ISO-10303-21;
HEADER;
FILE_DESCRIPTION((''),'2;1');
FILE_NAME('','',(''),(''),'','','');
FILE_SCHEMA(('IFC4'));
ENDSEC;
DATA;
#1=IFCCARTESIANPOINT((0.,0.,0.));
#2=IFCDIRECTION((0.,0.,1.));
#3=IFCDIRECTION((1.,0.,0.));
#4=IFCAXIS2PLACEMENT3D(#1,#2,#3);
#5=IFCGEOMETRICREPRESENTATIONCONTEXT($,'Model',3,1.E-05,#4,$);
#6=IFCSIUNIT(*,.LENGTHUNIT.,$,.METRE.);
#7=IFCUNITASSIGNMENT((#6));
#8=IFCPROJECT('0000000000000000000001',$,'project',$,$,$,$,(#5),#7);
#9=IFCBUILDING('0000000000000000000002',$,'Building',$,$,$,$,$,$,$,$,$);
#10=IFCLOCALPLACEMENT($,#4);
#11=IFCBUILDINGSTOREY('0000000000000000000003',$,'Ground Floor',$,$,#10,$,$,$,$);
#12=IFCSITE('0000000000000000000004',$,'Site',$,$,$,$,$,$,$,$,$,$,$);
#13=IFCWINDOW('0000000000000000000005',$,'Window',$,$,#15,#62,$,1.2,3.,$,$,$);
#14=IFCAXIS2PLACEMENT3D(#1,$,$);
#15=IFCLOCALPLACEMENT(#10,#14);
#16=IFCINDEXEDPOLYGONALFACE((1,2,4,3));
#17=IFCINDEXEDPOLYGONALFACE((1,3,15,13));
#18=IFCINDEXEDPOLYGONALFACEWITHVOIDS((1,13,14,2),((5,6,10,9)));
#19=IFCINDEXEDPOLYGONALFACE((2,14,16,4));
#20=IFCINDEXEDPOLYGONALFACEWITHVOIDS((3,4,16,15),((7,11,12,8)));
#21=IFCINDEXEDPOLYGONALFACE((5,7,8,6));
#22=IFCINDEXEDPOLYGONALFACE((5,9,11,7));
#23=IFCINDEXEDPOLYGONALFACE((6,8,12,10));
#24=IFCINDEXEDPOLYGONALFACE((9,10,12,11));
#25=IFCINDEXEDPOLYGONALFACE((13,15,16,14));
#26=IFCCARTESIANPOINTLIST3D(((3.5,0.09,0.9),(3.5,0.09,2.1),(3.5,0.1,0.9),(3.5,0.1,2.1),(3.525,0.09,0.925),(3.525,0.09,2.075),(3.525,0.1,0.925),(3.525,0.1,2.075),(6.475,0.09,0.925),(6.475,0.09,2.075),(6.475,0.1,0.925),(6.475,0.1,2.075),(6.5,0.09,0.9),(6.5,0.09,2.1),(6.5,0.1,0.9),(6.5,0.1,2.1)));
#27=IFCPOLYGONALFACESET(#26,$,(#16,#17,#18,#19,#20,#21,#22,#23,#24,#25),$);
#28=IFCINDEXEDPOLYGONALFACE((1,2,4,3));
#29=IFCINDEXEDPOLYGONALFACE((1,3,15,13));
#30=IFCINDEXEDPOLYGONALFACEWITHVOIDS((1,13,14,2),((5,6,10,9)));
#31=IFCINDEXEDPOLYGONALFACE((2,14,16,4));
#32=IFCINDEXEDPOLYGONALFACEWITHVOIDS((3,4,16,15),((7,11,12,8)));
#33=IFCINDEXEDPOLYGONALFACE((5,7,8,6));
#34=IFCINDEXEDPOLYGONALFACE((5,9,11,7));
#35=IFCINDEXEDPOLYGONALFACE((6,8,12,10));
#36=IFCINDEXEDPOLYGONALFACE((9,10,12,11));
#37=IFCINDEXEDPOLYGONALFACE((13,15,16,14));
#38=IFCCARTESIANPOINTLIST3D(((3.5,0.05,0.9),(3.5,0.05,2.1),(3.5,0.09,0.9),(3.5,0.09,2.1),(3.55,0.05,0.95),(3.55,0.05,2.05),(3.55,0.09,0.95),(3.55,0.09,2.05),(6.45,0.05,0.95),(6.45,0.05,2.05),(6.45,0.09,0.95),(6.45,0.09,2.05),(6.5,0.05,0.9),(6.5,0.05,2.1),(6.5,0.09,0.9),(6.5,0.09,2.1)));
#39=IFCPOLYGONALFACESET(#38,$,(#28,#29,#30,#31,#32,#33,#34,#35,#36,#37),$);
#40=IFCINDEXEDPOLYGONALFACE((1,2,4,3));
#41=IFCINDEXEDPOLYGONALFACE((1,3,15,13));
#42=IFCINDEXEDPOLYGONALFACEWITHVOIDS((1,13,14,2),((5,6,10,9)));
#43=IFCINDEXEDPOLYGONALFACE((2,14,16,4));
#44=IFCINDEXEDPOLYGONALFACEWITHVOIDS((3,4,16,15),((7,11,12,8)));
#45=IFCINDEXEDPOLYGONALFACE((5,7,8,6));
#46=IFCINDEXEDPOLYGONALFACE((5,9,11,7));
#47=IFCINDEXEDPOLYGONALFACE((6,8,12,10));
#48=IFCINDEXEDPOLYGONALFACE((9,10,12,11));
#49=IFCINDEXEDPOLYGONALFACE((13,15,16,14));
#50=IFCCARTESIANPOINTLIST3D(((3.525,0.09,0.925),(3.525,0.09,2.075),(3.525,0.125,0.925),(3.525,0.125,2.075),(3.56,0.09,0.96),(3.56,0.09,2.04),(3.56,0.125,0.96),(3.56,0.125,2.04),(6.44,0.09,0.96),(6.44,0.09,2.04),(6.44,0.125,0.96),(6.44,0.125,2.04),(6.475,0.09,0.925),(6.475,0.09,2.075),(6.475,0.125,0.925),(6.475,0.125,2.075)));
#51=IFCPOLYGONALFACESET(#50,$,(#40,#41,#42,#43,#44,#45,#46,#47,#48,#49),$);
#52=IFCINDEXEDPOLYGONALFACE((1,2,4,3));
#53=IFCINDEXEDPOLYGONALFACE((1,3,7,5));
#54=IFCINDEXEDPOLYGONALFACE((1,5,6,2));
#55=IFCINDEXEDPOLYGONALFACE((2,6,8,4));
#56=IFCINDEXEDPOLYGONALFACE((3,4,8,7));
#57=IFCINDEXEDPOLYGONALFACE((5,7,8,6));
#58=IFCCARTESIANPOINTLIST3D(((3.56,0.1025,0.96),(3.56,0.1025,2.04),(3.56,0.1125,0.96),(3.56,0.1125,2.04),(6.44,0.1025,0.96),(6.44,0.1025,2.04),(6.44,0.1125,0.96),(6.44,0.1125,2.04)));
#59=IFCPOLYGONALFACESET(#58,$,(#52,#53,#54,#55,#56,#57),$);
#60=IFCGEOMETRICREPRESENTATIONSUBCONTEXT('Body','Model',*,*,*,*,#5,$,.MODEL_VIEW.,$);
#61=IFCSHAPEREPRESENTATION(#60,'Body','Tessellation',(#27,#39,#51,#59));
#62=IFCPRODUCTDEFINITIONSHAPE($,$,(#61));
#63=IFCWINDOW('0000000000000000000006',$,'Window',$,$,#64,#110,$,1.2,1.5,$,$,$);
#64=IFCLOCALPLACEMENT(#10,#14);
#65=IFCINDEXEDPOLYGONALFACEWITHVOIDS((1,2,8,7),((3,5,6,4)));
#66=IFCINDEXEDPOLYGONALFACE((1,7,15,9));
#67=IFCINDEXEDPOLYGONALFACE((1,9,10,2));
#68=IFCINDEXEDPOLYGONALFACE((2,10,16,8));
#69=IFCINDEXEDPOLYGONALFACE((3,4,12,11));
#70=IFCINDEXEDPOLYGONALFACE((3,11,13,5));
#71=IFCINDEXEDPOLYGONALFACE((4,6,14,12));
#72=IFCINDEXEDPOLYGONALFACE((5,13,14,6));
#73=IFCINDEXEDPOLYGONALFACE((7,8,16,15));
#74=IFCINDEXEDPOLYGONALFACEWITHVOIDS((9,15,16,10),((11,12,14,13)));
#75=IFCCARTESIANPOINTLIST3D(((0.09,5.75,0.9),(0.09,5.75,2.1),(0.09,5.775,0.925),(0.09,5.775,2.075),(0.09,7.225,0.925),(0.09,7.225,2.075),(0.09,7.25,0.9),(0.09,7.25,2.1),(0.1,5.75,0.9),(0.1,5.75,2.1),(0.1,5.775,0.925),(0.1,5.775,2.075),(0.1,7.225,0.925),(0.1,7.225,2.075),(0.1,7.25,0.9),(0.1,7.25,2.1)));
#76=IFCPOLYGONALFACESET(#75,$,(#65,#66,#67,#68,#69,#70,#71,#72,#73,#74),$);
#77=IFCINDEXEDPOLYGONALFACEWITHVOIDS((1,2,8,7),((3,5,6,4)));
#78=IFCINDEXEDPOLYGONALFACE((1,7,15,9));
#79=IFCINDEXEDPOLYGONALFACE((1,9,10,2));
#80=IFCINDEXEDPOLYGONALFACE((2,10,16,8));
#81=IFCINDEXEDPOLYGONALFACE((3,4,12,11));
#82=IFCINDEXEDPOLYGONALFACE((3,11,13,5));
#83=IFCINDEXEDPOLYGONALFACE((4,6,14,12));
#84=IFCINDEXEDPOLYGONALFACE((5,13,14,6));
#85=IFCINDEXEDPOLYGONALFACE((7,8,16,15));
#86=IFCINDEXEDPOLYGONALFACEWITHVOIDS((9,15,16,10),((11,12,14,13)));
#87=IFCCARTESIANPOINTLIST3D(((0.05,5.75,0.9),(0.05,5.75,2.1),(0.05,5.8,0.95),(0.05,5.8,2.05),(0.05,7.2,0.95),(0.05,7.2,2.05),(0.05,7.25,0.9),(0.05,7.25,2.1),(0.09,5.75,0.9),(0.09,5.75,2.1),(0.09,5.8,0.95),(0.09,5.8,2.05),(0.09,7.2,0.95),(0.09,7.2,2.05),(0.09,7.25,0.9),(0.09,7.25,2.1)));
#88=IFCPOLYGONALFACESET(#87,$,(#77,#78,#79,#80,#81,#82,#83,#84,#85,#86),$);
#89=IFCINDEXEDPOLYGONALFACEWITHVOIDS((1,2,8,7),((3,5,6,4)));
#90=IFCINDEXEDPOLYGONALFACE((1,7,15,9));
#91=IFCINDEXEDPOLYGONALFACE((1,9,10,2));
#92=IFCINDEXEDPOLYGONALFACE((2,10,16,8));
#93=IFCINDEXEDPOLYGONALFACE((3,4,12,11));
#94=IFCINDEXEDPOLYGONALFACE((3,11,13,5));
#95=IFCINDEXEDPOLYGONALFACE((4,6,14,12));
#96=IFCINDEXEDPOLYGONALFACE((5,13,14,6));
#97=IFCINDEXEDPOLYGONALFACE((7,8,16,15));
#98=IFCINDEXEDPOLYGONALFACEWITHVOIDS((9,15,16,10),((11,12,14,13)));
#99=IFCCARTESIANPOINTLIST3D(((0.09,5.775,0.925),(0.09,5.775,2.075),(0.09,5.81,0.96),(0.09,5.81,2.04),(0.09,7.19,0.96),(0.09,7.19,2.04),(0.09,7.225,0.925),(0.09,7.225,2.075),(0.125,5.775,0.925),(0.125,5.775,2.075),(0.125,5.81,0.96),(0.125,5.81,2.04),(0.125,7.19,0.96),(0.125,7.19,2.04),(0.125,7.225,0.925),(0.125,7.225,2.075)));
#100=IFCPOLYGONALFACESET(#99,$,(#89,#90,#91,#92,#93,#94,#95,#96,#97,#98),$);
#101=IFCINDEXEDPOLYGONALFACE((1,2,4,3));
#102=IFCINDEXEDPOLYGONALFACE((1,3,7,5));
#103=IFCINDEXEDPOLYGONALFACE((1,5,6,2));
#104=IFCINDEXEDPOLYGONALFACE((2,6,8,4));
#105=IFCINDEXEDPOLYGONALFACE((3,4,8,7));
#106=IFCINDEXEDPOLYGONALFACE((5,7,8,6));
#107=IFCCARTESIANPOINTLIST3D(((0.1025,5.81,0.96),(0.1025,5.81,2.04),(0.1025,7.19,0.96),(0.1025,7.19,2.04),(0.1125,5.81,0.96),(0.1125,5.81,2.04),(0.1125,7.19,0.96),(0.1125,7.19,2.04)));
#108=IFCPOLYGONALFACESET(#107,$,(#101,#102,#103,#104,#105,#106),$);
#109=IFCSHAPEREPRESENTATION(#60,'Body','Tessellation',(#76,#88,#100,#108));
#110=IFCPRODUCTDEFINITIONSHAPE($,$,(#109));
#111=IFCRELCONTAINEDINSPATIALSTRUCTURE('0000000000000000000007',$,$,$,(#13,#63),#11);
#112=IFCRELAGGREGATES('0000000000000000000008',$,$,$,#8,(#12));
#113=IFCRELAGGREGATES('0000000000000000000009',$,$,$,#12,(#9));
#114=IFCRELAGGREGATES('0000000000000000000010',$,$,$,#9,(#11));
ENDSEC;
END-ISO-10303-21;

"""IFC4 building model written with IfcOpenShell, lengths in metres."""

from ifc_helpers import new_model, si_unit, frame, origin_with_axes, place, context, subcontext, project, spatial, line, indexed_curve, outline, extrude, element, save


model = new_model("IFC4")

# Units and contexts
model_context = context("Model", 3, precision=1e-05, world=origin_with_axes())
body_context = subcontext(model_context, "Body", "Model", "MODEL_VIEW")
ifc_project = project(units=[si_unit("LENGTHUNIT", "METRE")], contexts=[model_context])

# Site, building, storey
site = spatial("IfcSite", under=ifc_project, Name="Site")
building = spatial("IfcBuilding", under=site, Name="Building")
storey_placement = place(None, origin_with_axes())
storey = spatial("IfcBuildingStorey", under=building, at=storey_placement, Name="Ground Floor")

# Windows
window_1_placement = place(storey_placement, frame((3.5, 0.0, 0.9), z_axis=(0.0, 0.0, 1.0), x_axis=(1.0, 0.0, 0.0)))
element("IfcWindow", 1, at=window_1_placement, inside=storey, Name="Window", OverallHeight=1.2, OverallWidth=3.0, context=body_context, shape_type="SweptSolid", body=[
    extrude(outline(indexed_curve([(0.0, 0.0), (3.0, 0.0), (3.0, 1.2), (0.0, 1.2)], segments=[line(1, 2, 3, 4, 1)]), holes=[indexed_curve([(0.025, 0.025), (2.975, 0.025), (2.975, 1.175), (0.025, 1.175)], segments=[line(1, 2, 3, 4, 1)])]), frame((0.0, 0.09, 0.0), z_axis=(0.0, -1.0, 0.0), x_axis=(1.0, 0.0, 0.0)), (0.0, 0.0, -1.0), 0.01),
    extrude(outline(indexed_curve([(0.0, 0.0), (3.0, 0.0), (3.0, 1.2), (0.0, 1.2)], segments=[line(1, 2, 3, 4, 1)]), holes=[indexed_curve([(0.05, 0.05), (2.95, 0.05), (2.95, 1.15), (0.05, 1.15)], segments=[line(1, 2, 3, 4, 1)])]), frame((0.0, 0.05, 0.0), z_axis=(0.0, -1.0, 0.0), x_axis=(1.0, 0.0, 0.0)), (0.0, 0.0, -1.0), 0.04),
    extrude(outline(indexed_curve([(0.0, 0.0), (2.95, 0.0), (2.95, 1.15), (0.0, 1.15)], segments=[line(1, 2, 3, 4, 1)]), holes=[indexed_curve([(0.035, 0.035), (2.915, 0.035), (2.915, 1.115), (0.035, 1.115)], segments=[line(1, 2, 3, 4, 1)])]), frame((0.025, 0.09, 0.025), z_axis=(0.0, -1.0, 0.0), x_axis=(1.0, 0.0, 0.0)), (0.0, 0.0, -1.0), 0.035),
    extrude(outline(indexed_curve([(0.035, 0.035), (2.915, 0.035), (2.915, 1.115), (0.035, 1.115)], segments=[line(1, 2, 3, 4, 1)])), frame((0.025, 0.1025, 0.025), z_axis=(0.0, -1.0, 0.0), x_axis=(1.0, 0.0, 0.0)), (0.0, 0.0, -1.0), 0.01),
])
window_2_placement = place(storey_placement, frame((0.0, 7.25, 0.9), z_axis=(0.0, 0.0, 1.0), x_axis=(0.0, -1.0, 0.0)))
element("IfcWindow", 2, at=window_2_placement, inside=storey, Name="Window", OverallHeight=1.2, OverallWidth=1.5, context=body_context, shape_type="SweptSolid", body=[
    extrude(outline(indexed_curve([(0.0, 0.0), (1.5, 0.0), (1.5, 1.2), (0.0, 1.2)], segments=[line(1, 2, 3, 4, 1)]), holes=[indexed_curve([(0.025, 0.025), (1.475, 0.025), (1.475, 1.175), (0.025, 1.175)], segments=[line(1, 2, 3, 4, 1)])]), frame((0.0, 0.09, 0.0), z_axis=(0.0, -1.0, 0.0), x_axis=(1.0, 0.0, 0.0)), (0.0, 0.0, -1.0), 0.01),
    extrude(outline(indexed_curve([(0.0, 0.0), (1.5, 0.0), (1.5, 1.2), (0.0, 1.2)], segments=[line(1, 2, 3, 4, 1)]), holes=[indexed_curve([(0.05, 0.05), (1.45, 0.05), (1.45, 1.15), (0.05, 1.15)], segments=[line(1, 2, 3, 4, 1)])]), frame((0.0, 0.05, 0.0), z_axis=(0.0, -1.0, 0.0), x_axis=(1.0, 0.0, 0.0)), (0.0, 0.0, -1.0), 0.04),
    extrude(outline(indexed_curve([(0.0, 0.0), (1.45, 0.0), (1.45, 1.15), (0.0, 1.15)], segments=[line(1, 2, 3, 4, 1)]), holes=[indexed_curve([(0.035, 0.035), (1.415, 0.035), (1.415, 1.115), (0.035, 1.115)], segments=[line(1, 2, 3, 4, 1)])]), frame((0.025, 0.09, 0.025), z_axis=(0.0, -1.0, 0.0), x_axis=(1.0, 0.0, 0.0)), (0.0, 0.0, -1.0), 0.035),
    extrude(outline(indexed_curve([(0.035, 0.035), (1.415, 0.035), (1.415, 1.115), (0.035, 1.115)], segments=[line(1, 2, 3, 4, 1)])), frame((0.025, 0.1025, 0.025), z_axis=(0.0, -1.0, 0.0), x_axis=(1.0, 0.0, 0.0)), (0.0, 0.0, -1.0), 0.01),
])

save(model, "model.ifc")
